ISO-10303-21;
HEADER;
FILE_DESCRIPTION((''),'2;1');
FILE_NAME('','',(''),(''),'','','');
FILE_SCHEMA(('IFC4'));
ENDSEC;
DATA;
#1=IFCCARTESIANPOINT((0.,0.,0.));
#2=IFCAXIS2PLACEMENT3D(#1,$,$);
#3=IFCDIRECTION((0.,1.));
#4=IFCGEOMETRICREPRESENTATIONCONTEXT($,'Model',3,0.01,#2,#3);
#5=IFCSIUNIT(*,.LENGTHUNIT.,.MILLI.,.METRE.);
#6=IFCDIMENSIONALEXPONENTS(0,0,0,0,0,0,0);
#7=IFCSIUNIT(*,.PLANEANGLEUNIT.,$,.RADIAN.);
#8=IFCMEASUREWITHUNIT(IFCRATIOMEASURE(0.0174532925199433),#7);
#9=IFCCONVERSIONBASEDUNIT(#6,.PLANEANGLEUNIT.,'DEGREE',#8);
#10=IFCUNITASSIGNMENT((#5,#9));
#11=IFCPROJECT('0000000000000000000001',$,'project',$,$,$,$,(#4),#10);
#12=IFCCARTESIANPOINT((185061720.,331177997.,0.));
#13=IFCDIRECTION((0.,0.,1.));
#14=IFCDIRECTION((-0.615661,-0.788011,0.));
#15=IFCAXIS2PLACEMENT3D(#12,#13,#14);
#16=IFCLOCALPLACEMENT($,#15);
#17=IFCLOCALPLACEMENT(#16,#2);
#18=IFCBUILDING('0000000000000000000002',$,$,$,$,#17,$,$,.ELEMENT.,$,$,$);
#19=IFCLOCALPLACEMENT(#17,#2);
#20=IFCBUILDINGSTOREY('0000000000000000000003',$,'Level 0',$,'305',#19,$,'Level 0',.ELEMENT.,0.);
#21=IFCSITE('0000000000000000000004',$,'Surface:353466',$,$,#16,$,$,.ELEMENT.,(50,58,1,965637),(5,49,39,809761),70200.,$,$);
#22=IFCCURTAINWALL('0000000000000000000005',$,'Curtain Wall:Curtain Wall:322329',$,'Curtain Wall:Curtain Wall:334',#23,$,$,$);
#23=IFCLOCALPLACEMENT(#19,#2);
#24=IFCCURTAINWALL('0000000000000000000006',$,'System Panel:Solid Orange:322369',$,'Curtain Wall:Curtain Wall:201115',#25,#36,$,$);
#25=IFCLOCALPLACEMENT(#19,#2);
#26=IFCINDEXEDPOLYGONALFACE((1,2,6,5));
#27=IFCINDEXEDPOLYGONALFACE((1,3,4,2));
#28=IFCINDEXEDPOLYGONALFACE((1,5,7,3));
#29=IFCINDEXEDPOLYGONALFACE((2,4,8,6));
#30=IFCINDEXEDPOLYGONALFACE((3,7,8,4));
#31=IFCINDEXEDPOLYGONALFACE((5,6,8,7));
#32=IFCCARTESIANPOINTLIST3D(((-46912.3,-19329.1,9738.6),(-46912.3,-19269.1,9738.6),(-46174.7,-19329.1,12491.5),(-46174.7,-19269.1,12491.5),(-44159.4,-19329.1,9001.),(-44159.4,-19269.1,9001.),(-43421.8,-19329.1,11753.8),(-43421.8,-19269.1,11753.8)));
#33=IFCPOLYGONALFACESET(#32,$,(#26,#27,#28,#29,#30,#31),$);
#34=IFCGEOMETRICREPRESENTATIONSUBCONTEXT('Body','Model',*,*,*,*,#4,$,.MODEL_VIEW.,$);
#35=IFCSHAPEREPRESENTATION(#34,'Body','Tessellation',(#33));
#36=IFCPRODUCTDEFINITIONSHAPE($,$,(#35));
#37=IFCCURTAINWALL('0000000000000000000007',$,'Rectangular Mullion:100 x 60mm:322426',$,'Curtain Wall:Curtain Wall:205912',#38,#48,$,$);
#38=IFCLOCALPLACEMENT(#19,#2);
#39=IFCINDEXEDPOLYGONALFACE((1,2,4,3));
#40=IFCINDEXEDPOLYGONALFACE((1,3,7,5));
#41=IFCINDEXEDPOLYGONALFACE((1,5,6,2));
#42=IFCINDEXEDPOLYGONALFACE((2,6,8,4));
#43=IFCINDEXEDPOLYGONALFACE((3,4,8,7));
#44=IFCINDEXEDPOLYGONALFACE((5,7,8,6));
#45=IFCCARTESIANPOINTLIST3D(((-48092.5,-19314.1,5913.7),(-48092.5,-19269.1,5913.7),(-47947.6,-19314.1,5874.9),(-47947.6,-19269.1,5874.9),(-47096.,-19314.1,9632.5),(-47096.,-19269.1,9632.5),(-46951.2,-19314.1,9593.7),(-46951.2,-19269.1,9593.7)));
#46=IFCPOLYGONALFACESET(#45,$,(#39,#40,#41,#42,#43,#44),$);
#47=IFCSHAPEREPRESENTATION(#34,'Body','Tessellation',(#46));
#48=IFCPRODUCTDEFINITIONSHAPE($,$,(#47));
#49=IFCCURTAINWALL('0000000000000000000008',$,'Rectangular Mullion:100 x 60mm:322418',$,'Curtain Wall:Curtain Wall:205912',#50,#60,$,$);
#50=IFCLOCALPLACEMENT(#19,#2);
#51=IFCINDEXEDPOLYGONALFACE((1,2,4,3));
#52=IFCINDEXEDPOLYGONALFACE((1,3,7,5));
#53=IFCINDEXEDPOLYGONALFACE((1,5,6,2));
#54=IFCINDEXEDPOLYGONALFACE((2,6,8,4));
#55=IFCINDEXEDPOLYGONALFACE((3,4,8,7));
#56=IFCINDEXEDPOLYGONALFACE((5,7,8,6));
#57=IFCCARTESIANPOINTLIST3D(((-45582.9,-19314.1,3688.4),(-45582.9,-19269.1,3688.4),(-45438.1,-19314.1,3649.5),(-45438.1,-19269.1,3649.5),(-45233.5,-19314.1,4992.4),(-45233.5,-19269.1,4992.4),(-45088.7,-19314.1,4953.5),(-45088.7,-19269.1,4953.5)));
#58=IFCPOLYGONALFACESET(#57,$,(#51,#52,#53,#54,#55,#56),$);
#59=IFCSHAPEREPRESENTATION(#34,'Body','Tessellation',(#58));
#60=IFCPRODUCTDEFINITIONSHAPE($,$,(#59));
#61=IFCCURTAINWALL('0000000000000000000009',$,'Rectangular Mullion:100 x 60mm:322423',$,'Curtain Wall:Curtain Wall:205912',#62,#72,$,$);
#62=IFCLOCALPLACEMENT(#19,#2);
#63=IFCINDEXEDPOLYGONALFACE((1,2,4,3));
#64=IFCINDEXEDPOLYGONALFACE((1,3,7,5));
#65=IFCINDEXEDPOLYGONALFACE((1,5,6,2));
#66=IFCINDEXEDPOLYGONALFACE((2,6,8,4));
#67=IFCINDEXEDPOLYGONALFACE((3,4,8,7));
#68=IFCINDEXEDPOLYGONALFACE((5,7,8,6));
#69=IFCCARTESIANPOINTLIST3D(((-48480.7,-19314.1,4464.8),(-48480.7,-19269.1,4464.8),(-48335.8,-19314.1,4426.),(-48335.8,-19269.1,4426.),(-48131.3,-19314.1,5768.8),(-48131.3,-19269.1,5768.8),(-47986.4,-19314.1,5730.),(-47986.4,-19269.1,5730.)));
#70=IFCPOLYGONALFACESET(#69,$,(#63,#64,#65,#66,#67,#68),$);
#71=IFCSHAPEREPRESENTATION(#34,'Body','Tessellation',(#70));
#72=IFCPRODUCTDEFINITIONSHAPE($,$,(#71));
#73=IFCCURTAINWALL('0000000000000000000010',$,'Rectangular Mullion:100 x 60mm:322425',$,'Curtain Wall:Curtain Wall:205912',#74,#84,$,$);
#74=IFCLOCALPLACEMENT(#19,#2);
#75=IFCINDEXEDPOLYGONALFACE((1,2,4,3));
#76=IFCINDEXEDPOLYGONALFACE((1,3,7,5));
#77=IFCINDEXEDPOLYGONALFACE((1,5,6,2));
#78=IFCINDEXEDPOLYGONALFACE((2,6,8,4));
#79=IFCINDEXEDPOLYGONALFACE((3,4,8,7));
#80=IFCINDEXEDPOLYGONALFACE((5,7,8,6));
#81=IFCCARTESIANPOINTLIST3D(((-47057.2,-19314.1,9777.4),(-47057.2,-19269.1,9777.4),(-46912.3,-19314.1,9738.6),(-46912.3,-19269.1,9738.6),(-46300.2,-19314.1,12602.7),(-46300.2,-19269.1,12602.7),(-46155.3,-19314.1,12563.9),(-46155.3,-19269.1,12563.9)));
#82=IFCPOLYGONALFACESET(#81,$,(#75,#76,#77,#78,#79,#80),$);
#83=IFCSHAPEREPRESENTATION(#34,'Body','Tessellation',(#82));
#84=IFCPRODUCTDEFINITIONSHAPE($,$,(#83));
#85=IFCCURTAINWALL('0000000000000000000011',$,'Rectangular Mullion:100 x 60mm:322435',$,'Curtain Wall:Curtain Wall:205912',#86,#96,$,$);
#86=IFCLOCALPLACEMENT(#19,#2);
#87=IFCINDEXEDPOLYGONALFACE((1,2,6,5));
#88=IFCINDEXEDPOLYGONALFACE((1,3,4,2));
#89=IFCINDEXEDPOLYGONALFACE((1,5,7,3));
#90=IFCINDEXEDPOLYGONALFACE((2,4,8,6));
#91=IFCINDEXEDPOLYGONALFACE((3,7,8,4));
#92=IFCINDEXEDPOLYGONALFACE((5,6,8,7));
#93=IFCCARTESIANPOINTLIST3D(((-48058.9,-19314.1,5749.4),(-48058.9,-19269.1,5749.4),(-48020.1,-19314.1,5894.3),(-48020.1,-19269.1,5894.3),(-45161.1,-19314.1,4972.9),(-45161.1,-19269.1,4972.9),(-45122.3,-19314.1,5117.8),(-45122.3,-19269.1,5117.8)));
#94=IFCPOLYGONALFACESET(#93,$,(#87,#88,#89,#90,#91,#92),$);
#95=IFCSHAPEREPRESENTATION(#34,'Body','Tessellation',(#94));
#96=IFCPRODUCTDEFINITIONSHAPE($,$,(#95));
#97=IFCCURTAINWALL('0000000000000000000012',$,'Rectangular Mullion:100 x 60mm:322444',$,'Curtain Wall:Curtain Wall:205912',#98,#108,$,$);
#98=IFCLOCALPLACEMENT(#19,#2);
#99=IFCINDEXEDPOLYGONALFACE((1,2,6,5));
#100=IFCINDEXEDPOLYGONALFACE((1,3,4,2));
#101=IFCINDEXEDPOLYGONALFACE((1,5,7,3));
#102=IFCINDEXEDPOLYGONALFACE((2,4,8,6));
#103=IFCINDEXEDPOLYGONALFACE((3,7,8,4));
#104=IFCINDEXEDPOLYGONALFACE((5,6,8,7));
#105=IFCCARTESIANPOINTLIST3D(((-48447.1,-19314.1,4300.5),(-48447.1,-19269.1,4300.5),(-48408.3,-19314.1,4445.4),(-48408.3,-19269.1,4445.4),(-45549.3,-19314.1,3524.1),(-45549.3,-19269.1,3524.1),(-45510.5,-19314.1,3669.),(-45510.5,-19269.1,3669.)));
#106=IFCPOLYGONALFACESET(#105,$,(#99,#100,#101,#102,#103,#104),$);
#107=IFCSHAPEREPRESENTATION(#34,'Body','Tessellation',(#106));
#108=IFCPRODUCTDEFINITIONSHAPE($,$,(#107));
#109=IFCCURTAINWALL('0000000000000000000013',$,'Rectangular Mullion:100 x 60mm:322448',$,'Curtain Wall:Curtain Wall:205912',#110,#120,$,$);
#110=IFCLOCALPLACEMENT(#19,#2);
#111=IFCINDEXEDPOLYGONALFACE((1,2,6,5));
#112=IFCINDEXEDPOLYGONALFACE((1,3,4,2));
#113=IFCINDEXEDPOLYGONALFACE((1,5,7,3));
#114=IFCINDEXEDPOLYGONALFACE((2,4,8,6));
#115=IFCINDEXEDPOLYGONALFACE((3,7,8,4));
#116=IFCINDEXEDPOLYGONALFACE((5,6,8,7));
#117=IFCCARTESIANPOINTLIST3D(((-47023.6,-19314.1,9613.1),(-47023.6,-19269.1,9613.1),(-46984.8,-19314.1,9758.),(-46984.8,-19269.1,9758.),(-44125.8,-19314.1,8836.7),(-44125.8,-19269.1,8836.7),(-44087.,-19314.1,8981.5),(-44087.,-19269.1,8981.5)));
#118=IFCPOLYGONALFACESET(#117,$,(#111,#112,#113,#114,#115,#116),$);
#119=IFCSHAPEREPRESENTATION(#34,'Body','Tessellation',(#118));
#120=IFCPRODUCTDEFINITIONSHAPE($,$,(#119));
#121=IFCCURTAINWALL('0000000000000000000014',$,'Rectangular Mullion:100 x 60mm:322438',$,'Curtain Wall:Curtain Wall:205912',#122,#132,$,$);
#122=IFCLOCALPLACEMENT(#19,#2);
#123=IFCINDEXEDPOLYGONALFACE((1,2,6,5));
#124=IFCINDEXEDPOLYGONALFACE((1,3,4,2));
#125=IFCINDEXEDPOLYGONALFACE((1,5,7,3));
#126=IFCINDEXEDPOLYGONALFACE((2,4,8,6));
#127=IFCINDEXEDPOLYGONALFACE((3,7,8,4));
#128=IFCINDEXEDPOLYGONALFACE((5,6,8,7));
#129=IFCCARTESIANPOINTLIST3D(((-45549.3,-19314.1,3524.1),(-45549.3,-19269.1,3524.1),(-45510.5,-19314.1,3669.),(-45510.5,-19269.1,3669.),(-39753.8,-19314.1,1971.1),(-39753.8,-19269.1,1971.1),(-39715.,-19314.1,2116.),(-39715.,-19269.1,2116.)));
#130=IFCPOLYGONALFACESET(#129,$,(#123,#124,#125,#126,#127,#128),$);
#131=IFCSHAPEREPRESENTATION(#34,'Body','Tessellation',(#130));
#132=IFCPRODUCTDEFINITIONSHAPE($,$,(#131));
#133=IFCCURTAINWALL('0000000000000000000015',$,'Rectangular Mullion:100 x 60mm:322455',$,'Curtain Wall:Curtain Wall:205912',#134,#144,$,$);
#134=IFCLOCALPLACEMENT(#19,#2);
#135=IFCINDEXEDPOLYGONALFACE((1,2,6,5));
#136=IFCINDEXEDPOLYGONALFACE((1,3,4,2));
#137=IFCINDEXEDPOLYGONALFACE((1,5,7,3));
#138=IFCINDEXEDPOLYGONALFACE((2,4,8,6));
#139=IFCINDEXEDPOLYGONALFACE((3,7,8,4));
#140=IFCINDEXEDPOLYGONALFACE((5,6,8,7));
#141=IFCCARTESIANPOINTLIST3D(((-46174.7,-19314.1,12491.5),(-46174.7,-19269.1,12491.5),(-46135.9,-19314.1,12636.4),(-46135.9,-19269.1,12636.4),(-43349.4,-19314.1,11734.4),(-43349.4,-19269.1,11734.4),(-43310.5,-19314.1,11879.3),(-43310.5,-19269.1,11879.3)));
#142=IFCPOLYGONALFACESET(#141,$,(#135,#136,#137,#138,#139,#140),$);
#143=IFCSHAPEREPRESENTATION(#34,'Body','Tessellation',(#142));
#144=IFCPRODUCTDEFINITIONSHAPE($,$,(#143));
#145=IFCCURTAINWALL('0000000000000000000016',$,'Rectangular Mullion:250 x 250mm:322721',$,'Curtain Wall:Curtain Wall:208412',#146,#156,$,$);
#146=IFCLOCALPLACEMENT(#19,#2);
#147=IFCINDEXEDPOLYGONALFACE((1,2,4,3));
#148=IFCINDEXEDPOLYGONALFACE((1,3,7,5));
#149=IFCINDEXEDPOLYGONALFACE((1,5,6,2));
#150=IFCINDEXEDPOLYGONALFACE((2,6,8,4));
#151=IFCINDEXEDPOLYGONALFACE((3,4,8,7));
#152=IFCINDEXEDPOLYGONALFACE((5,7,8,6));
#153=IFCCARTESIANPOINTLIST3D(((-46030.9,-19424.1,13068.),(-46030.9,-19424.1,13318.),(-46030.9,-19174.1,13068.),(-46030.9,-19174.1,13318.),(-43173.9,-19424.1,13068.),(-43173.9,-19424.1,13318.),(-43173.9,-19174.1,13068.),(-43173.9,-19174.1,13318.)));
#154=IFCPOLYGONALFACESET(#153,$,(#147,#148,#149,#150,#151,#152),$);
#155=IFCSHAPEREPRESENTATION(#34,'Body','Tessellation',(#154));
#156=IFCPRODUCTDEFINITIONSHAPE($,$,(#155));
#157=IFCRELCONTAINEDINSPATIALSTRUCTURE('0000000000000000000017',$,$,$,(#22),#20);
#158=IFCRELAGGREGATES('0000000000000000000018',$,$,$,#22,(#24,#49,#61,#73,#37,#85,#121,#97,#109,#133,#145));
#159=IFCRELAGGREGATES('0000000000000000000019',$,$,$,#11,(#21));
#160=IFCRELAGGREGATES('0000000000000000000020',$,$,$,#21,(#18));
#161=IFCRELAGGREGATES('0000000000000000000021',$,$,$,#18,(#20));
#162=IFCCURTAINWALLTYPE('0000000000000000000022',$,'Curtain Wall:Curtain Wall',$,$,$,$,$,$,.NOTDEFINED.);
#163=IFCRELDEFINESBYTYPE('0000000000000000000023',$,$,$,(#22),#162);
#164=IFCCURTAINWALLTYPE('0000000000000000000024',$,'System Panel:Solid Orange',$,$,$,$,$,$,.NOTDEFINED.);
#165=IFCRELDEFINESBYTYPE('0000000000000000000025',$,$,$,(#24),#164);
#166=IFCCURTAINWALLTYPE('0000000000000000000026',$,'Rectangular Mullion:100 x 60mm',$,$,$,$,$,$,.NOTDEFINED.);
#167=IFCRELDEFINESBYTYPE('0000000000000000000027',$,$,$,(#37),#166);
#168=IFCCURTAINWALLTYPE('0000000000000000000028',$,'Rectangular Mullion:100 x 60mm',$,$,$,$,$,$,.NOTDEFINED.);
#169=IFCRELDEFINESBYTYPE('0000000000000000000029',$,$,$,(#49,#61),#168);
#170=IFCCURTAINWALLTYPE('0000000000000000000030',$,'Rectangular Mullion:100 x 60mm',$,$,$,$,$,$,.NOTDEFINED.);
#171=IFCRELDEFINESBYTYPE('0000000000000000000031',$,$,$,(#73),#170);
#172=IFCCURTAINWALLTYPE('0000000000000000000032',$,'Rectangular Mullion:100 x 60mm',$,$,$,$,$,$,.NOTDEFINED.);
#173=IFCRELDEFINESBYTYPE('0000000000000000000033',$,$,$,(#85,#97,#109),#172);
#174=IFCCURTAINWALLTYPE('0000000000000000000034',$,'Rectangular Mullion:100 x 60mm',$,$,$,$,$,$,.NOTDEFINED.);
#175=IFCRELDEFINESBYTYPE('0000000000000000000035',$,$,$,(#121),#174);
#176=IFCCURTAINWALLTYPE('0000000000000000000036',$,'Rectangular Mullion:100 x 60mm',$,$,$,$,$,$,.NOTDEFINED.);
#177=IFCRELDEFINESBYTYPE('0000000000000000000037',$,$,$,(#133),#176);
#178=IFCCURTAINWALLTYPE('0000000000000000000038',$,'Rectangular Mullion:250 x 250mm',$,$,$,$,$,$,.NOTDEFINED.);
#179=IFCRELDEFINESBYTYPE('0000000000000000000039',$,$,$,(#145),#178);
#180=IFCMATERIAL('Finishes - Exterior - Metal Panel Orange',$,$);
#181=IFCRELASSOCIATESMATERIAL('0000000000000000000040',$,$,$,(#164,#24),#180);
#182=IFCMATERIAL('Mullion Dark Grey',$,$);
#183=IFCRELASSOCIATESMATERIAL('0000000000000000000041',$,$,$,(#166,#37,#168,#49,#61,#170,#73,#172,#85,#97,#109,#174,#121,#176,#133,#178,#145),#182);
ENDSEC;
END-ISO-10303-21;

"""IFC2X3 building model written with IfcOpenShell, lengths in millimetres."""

from ifc_helpers import new_model, entity, si_unit, converted_unit, direction, frame, frame_2d, origin, origin_2d_with_axis, place, context, subcontext, project, spatial, rectangle, extrude, source, transform, mapped, material, type_object, type_shapes, element, aggregate, save


model = new_model("IFC2X3")

# Units and contexts
model_context = context("Model", 3, precision=0.01, world=origin(), true_north=direction((0.0, 1.0)))
body_context = subcontext(model_context, "Body", "Model", "MODEL_VIEW")
ifc_project = project(units=[si_unit("LENGTHUNIT", "METRE", prefix="MILLI"), converted_unit("PLANEANGLEUNIT", "DEGREE", entity("IfcRatioMeasure", 0.0174532925199433), si_unit("PLANEANGLEUNIT", "RADIAN"), dimensions=[0, 0, 0, 0, 0, 0, 0])], contexts=[model_context])

# Site, building, storey
site_placement = place(None, frame((185061720.0, 331177997.0, 0.0), z_axis=(0.0, 0.0, 1.0), x_axis=(-0.615661, -0.788011, 0.0)))
site = spatial("IfcSite", under=ifc_project, at=site_placement, Name="Surface:353466", CompositionType="ELEMENT", RefLatitude=(50, 58, 1, 965637), RefLongitude=(5, 49, 39, 809761), RefElevation=70200.0)
building_placement = place(site_placement, origin())
building = spatial("IfcBuilding", under=site, at=building_placement, CompositionType="ELEMENT")
storey_placement = place(building_placement, origin())
storey = spatial("IfcBuildingStorey", under=building, at=storey_placement, Name="Level 0", ObjectType="305", LongName="Level 0", CompositionType="ELEMENT", Elevation=0.0)

# Curtain walls
curtain_wall_type_1 = type_object("IfcCurtainWallType", Name="Curtain Wall:Curtain Wall", PredefinedType="NOTDEFINED")
curtain_wall_1_placement = place(storey_placement, origin())
curtain_wall_1 = element("IfcCurtainWall", 1, at=curtain_wall_1_placement, inside=storey, type_object=curtain_wall_type_1, Name="Curtain Wall:Curtain Wall:322329", ObjectType="Curtain Wall:Curtain Wall:334")
ifc_material_1 = material(Name="Finishes - Exterior - Metal Panel Orange")
curtain_wall_type_2 = type_object("IfcCurtainWallType", Name="System Panel:Solid Orange", PredefinedType="NOTDEFINED", material=ifc_material_1)
shared_shape_1 = source(origin(), body_context, "Body", "SweptSolid", [
    extrude(rectangle(XDim=60.0, YDim=2850.0, at=frame_2d((0.0, 0.0), x_axis=(1.0, 0.0))), frame((0.0, 0.0, 0.0), z_axis=(0.0, 0.0, 1.0), x_axis=(0.0, 1.0, 0.0)), (0.0, 0.0, 1.0), 2850.0),
])
type_shapes(curtain_wall_type_2, [shared_shape_1])
curtain_wall_2_placement = place(storey_placement, frame((-45535.9, -19299.1, 9369.8), z_axis=(0.258819, 0.0, 0.965926), x_axis=(-0.965926, 0.0, 0.258819)))
curtain_wall_2 = element("IfcCurtainWall", 2, at=curtain_wall_2_placement, type_object=curtain_wall_type_2, material=ifc_material_1, Name="System Panel:Solid Orange:322369", ObjectType="Curtain Wall:Curtain Wall:201115", context=body_context, shape_type="MappedRepresentation", body=[
    mapped(shared_shape_1, transform((0.0, 0.0, 0.0), scale=1.0)),
])
ifc_material_2 = material(Name="Mullion Dark Grey")
curtain_wall_type_3 = type_object("IfcCurtainWallType", Name="Rectangular Mullion:100 x 60mm", PredefinedType="NOTDEFINED", material=ifc_material_2)
shared_shape_2 = source(origin(), body_context, "Body", "SweptSolid", [
    extrude(rectangle(XDim=45.0, YDim=150.0, at=frame_2d((0.0, 0.0), x_axis=(1.0, 0.0))), frame((0.0, 7.5, -3850.0), z_axis=(0.0, 0.0, 1.0), x_axis=(0.0, -1.0, 0.0)), (0.0, 0.0, 1.0), 3850.0),
])
type_shapes(curtain_wall_type_3, [shared_shape_2])
curtain_wall_3_placement = place(storey_placement, frame((-48020.1, -19299.1, 5894.3), z_axis=(-0.258819, 0.0, -0.965926), x_axis=(-0.965926, 0.0, 0.258819)))
curtain_wall_3 = element("IfcCurtainWall", 3, at=curtain_wall_3_placement, type_object=curtain_wall_type_3, material=ifc_material_2, Name="Rectangular Mullion:100 x 60mm:322426", ObjectType="Curtain Wall:Curtain Wall:205912", context=body_context, shape_type="MappedRepresentation", body=[
    mapped(shared_shape_2, transform((0.0, 0.0, 0.0), scale=1.0)),
])
curtain_wall_type_4 = type_object("IfcCurtainWallType", Name="Rectangular Mullion:100 x 60mm", PredefinedType="NOTDEFINED", material=ifc_material_2)
shared_shape_3 = source(origin(), body_context, "Body", "SweptSolid", [
    extrude(rectangle(XDim=45.0, YDim=150.0, at=frame_2d((0.0, 0.0), x_axis=(1.0, 0.0))), frame((0.0, 7.5, -1350.0), z_axis=(0.0, 0.0, 1.0), x_axis=(0.0, -1.0, 0.0)), (0.0, 0.0, 1.0), 1350.0),
])
type_shapes(curtain_wall_type_4, [shared_shape_3])
curtain_wall_4_placement = place(storey_placement, frame((-45510.5, -19299.1, 3669.0), z_axis=(-0.258819, 0.0, -0.965926), x_axis=(-0.965926, 0.0, 0.258819)))
curtain_wall_4 = element("IfcCurtainWall", 4, at=curtain_wall_4_placement, type_object=curtain_wall_type_4, material=ifc_material_2, Name="Rectangular Mullion:100 x 60mm:322418", ObjectType="Curtain Wall:Curtain Wall:205912", context=body_context, shape_type="MappedRepresentation", body=[
    mapped(shared_shape_3, transform((0.0, 0.0, 0.0), scale=1.0)),
])
curtain_wall_5_placement = place(storey_placement, frame((-48408.3, -19299.1, 4445.4), z_axis=(-0.258819, 0.0, -0.965926), x_axis=(-0.965926, 0.0, 0.258819)))
curtain_wall_5 = element("IfcCurtainWall", 5, at=curtain_wall_5_placement, type_object=curtain_wall_type_4, material=ifc_material_2, Name="Rectangular Mullion:100 x 60mm:322423", ObjectType="Curtain Wall:Curtain Wall:205912", context=body_context, shape_type="MappedRepresentation", body=[
    mapped(shared_shape_3, transform((0.0, 0.0, 0.0), scale=1.0)),
])
curtain_wall_type_5 = type_object("IfcCurtainWallType", Name="Rectangular Mullion:100 x 60mm", PredefinedType="NOTDEFINED", material=ifc_material_2)
shared_shape_4 = source(origin(), body_context, "Body", "SweptSolid", [
    extrude(rectangle(XDim=45.0, YDim=150.0, at=frame_2d((0.0, 0.0), x_axis=(1.0, 0.0))), frame((0.0, 7.5, -2925.0), z_axis=(0.0, 0.0, 1.0), x_axis=(0.0, -1.0, 0.0)), (0.0, 0.0, 1.0), 2925.0),
])
type_shapes(curtain_wall_type_5, [shared_shape_4])
curtain_wall_6_placement = place(storey_placement, frame((-46984.8, -19299.1, 9758.0), z_axis=(-0.258819, 0.0, -0.965926), x_axis=(-0.965926, 0.0, 0.258819)))
curtain_wall_6 = element("IfcCurtainWall", 6, at=curtain_wall_6_placement, type_object=curtain_wall_type_5, material=ifc_material_2, Name="Rectangular Mullion:100 x 60mm:322425", ObjectType="Curtain Wall:Curtain Wall:205912", context=body_context, shape_type="MappedRepresentation", body=[
    mapped(shared_shape_4, transform((0.0, 0.0, 0.0), scale=1.0)),
])
curtain_wall_type_6 = type_object("IfcCurtainWallType", Name="Rectangular Mullion:100 x 60mm", PredefinedType="NOTDEFINED", material=ifc_material_2)
shared_shape_5 = source(origin(), body_context, "Body", "SweptSolid", [
    extrude(rectangle(XDim=45.0, YDim=150.0, at=frame_2d((0.0, 0.0), x_axis=(1.0, 0.0))), frame((0.0, 7.5, -3000.0), z_axis=(0.0, 0.0, 1.0), x_axis=(0.0, -1.0, 0.0)), (0.0, 0.0, 1.0), 3000.0),
])
type_shapes(curtain_wall_type_6, [shared_shape_5])
curtain_wall_7_placement = place(storey_placement, frame((-48039.5, -19299.1, 5821.9), z_axis=(-0.965926, 0.0, 0.258819), x_axis=(0.258819, 0.0, 0.965926)))
curtain_wall_7 = element("IfcCurtainWall", 7, at=curtain_wall_7_placement, type_object=curtain_wall_type_6, material=ifc_material_2, Name="Rectangular Mullion:100 x 60mm:322435", ObjectType="Curtain Wall:Curtain Wall:205912", context=body_context, shape_type="MappedRepresentation", body=[
    mapped(shared_shape_5, transform((0.0, 0.0, 0.0), scale=1.0)),
])
curtain_wall_8_placement = place(storey_placement, frame((-48427.7, -19299.1, 4373.0), z_axis=(-0.965926, 0.0, 0.258819), x_axis=(0.258819, 0.0, 0.965926)))
curtain_wall_8 = element("IfcCurtainWall", 8, at=curtain_wall_8_placement, type_object=curtain_wall_type_6, material=ifc_material_2, Name="Rectangular Mullion:100 x 60mm:322444", ObjectType="Curtain Wall:Curtain Wall:205912", context=body_context, shape_type="MappedRepresentation", body=[
    mapped(shared_shape_5, transform((0.0, 0.0, 0.0), scale=1.0)),
])
curtain_wall_9_placement = place(storey_placement, frame((-47004.2, -19299.1, 9685.6), z_axis=(-0.965926, 0.0, 0.258819), x_axis=(0.258819, 0.0, 0.965926)))
curtain_wall_9 = element("IfcCurtainWall", 9, at=curtain_wall_9_placement, type_object=curtain_wall_type_6, material=ifc_material_2, Name="Rectangular Mullion:100 x 60mm:322448", ObjectType="Curtain Wall:Curtain Wall:205912", context=body_context, shape_type="MappedRepresentation", body=[
    mapped(shared_shape_5, transform((0.0, 0.0, 0.0), scale=1.0)),
])
curtain_wall_type_7 = type_object("IfcCurtainWallType", Name="Rectangular Mullion:100 x 60mm", PredefinedType="NOTDEFINED", material=ifc_material_2)
shared_shape_6 = source(origin(), body_context, "Body", "SweptSolid", [
    extrude(rectangle(XDim=45.0, YDim=150.0, at=frame_2d((0.0, 0.0), x_axis=(1.0, 0.0))), frame((0.0, 7.5, -6000.0), z_axis=(0.0, 0.0, 1.0), x_axis=(0.0, -1.0, 0.0)), (0.0, 0.0, 1.0), 6000.0),
])
type_shapes(curtain_wall_type_7, [shared_shape_6])
curtain_wall_10_placement = place(storey_placement, frame((-45529.9, -19299.1, 3596.5), z_axis=(-0.965926, 0.0, 0.258819), x_axis=(0.258819, 0.0, 0.965926)))
curtain_wall_10 = element("IfcCurtainWall", 10, at=curtain_wall_10_placement, type_object=curtain_wall_type_7, material=ifc_material_2, Name="Rectangular Mullion:100 x 60mm:322438", ObjectType="Curtain Wall:Curtain Wall:205912", context=body_context, shape_type="MappedRepresentation", body=[
    mapped(shared_shape_6, transform((0.0, 0.0, 0.0), scale=1.0)),
])
curtain_wall_type_8 = type_object("IfcCurtainWallType", Name="Rectangular Mullion:100 x 60mm", PredefinedType="NOTDEFINED", material=ifc_material_2)
shared_shape_7 = source(origin(), body_context, "Body", "SweptSolid", [
    extrude(rectangle(XDim=45.0, YDim=150.0, at=frame_2d((0.0, 0.0), x_axis=(1.0, 0.0))), frame((0.0, 7.5, -2925.0), z_axis=(0.0, 0.0, 1.0), x_axis=(0.0, -1.0, 0.0)), (0.0, 0.0, 1.0), 2925.0),
])
type_shapes(curtain_wall_type_8, [shared_shape_7])
curtain_wall_11_placement = place(storey_placement, frame((-46155.3, -19299.1, 12563.9), z_axis=(-0.965926, 0.0, 0.258819), x_axis=(0.258819, 0.0, 0.965926)))
curtain_wall_11 = element("IfcCurtainWall", 11, at=curtain_wall_11_placement, type_object=curtain_wall_type_8, material=ifc_material_2, Name="Rectangular Mullion:100 x 60mm:322455", ObjectType="Curtain Wall:Curtain Wall:205912", context=body_context, shape_type="MappedRepresentation", body=[
    mapped(shared_shape_7, transform((0.0, 0.0, 0.0), scale=1.0)),
])
curtain_wall_type_9 = type_object("IfcCurtainWallType", Name="Rectangular Mullion:250 x 250mm", PredefinedType="NOTDEFINED", material=ifc_material_2)
shared_shape_8 = source(origin(), body_context, "Body", "SweptSolid", [
    extrude(rectangle(XDim=250.0, YDim=250.0, at=origin_2d_with_axis()), frame((-125.0, 0.0, -2857.0), z_axis=(0.0, 0.0, 1.0), x_axis=(-1.0, 0.0, 0.0)), (0.0, 0.0, 1.0), 2857.0),
])
type_shapes(curtain_wall_type_9, [shared_shape_8])
curtain_wall_12_placement = place(storey_placement, frame((-46030.9, -19299.1, 13318.0), z_axis=(-1.0, 0.0, 0.0), x_axis=(0.0, 0.0, 1.0)))
curtain_wall_12 = element("IfcCurtainWall", 12, at=curtain_wall_12_placement, type_object=curtain_wall_type_9, material=ifc_material_2, Name="Rectangular Mullion:250 x 250mm:322721", ObjectType="Curtain Wall:Curtain Wall:208412", context=body_context, shape_type="MappedRepresentation", body=[
    mapped(shared_shape_8, transform((0.0, 0.0, 0.0), scale=1.0)),
])
aggregate(curtain_wall_1, [curtain_wall_2, curtain_wall_4, curtain_wall_5, curtain_wall_6, curtain_wall_3, curtain_wall_7, curtain_wall_10, curtain_wall_8, curtain_wall_9, curtain_wall_11, curtain_wall_12])

save(model, "model.ifc")
